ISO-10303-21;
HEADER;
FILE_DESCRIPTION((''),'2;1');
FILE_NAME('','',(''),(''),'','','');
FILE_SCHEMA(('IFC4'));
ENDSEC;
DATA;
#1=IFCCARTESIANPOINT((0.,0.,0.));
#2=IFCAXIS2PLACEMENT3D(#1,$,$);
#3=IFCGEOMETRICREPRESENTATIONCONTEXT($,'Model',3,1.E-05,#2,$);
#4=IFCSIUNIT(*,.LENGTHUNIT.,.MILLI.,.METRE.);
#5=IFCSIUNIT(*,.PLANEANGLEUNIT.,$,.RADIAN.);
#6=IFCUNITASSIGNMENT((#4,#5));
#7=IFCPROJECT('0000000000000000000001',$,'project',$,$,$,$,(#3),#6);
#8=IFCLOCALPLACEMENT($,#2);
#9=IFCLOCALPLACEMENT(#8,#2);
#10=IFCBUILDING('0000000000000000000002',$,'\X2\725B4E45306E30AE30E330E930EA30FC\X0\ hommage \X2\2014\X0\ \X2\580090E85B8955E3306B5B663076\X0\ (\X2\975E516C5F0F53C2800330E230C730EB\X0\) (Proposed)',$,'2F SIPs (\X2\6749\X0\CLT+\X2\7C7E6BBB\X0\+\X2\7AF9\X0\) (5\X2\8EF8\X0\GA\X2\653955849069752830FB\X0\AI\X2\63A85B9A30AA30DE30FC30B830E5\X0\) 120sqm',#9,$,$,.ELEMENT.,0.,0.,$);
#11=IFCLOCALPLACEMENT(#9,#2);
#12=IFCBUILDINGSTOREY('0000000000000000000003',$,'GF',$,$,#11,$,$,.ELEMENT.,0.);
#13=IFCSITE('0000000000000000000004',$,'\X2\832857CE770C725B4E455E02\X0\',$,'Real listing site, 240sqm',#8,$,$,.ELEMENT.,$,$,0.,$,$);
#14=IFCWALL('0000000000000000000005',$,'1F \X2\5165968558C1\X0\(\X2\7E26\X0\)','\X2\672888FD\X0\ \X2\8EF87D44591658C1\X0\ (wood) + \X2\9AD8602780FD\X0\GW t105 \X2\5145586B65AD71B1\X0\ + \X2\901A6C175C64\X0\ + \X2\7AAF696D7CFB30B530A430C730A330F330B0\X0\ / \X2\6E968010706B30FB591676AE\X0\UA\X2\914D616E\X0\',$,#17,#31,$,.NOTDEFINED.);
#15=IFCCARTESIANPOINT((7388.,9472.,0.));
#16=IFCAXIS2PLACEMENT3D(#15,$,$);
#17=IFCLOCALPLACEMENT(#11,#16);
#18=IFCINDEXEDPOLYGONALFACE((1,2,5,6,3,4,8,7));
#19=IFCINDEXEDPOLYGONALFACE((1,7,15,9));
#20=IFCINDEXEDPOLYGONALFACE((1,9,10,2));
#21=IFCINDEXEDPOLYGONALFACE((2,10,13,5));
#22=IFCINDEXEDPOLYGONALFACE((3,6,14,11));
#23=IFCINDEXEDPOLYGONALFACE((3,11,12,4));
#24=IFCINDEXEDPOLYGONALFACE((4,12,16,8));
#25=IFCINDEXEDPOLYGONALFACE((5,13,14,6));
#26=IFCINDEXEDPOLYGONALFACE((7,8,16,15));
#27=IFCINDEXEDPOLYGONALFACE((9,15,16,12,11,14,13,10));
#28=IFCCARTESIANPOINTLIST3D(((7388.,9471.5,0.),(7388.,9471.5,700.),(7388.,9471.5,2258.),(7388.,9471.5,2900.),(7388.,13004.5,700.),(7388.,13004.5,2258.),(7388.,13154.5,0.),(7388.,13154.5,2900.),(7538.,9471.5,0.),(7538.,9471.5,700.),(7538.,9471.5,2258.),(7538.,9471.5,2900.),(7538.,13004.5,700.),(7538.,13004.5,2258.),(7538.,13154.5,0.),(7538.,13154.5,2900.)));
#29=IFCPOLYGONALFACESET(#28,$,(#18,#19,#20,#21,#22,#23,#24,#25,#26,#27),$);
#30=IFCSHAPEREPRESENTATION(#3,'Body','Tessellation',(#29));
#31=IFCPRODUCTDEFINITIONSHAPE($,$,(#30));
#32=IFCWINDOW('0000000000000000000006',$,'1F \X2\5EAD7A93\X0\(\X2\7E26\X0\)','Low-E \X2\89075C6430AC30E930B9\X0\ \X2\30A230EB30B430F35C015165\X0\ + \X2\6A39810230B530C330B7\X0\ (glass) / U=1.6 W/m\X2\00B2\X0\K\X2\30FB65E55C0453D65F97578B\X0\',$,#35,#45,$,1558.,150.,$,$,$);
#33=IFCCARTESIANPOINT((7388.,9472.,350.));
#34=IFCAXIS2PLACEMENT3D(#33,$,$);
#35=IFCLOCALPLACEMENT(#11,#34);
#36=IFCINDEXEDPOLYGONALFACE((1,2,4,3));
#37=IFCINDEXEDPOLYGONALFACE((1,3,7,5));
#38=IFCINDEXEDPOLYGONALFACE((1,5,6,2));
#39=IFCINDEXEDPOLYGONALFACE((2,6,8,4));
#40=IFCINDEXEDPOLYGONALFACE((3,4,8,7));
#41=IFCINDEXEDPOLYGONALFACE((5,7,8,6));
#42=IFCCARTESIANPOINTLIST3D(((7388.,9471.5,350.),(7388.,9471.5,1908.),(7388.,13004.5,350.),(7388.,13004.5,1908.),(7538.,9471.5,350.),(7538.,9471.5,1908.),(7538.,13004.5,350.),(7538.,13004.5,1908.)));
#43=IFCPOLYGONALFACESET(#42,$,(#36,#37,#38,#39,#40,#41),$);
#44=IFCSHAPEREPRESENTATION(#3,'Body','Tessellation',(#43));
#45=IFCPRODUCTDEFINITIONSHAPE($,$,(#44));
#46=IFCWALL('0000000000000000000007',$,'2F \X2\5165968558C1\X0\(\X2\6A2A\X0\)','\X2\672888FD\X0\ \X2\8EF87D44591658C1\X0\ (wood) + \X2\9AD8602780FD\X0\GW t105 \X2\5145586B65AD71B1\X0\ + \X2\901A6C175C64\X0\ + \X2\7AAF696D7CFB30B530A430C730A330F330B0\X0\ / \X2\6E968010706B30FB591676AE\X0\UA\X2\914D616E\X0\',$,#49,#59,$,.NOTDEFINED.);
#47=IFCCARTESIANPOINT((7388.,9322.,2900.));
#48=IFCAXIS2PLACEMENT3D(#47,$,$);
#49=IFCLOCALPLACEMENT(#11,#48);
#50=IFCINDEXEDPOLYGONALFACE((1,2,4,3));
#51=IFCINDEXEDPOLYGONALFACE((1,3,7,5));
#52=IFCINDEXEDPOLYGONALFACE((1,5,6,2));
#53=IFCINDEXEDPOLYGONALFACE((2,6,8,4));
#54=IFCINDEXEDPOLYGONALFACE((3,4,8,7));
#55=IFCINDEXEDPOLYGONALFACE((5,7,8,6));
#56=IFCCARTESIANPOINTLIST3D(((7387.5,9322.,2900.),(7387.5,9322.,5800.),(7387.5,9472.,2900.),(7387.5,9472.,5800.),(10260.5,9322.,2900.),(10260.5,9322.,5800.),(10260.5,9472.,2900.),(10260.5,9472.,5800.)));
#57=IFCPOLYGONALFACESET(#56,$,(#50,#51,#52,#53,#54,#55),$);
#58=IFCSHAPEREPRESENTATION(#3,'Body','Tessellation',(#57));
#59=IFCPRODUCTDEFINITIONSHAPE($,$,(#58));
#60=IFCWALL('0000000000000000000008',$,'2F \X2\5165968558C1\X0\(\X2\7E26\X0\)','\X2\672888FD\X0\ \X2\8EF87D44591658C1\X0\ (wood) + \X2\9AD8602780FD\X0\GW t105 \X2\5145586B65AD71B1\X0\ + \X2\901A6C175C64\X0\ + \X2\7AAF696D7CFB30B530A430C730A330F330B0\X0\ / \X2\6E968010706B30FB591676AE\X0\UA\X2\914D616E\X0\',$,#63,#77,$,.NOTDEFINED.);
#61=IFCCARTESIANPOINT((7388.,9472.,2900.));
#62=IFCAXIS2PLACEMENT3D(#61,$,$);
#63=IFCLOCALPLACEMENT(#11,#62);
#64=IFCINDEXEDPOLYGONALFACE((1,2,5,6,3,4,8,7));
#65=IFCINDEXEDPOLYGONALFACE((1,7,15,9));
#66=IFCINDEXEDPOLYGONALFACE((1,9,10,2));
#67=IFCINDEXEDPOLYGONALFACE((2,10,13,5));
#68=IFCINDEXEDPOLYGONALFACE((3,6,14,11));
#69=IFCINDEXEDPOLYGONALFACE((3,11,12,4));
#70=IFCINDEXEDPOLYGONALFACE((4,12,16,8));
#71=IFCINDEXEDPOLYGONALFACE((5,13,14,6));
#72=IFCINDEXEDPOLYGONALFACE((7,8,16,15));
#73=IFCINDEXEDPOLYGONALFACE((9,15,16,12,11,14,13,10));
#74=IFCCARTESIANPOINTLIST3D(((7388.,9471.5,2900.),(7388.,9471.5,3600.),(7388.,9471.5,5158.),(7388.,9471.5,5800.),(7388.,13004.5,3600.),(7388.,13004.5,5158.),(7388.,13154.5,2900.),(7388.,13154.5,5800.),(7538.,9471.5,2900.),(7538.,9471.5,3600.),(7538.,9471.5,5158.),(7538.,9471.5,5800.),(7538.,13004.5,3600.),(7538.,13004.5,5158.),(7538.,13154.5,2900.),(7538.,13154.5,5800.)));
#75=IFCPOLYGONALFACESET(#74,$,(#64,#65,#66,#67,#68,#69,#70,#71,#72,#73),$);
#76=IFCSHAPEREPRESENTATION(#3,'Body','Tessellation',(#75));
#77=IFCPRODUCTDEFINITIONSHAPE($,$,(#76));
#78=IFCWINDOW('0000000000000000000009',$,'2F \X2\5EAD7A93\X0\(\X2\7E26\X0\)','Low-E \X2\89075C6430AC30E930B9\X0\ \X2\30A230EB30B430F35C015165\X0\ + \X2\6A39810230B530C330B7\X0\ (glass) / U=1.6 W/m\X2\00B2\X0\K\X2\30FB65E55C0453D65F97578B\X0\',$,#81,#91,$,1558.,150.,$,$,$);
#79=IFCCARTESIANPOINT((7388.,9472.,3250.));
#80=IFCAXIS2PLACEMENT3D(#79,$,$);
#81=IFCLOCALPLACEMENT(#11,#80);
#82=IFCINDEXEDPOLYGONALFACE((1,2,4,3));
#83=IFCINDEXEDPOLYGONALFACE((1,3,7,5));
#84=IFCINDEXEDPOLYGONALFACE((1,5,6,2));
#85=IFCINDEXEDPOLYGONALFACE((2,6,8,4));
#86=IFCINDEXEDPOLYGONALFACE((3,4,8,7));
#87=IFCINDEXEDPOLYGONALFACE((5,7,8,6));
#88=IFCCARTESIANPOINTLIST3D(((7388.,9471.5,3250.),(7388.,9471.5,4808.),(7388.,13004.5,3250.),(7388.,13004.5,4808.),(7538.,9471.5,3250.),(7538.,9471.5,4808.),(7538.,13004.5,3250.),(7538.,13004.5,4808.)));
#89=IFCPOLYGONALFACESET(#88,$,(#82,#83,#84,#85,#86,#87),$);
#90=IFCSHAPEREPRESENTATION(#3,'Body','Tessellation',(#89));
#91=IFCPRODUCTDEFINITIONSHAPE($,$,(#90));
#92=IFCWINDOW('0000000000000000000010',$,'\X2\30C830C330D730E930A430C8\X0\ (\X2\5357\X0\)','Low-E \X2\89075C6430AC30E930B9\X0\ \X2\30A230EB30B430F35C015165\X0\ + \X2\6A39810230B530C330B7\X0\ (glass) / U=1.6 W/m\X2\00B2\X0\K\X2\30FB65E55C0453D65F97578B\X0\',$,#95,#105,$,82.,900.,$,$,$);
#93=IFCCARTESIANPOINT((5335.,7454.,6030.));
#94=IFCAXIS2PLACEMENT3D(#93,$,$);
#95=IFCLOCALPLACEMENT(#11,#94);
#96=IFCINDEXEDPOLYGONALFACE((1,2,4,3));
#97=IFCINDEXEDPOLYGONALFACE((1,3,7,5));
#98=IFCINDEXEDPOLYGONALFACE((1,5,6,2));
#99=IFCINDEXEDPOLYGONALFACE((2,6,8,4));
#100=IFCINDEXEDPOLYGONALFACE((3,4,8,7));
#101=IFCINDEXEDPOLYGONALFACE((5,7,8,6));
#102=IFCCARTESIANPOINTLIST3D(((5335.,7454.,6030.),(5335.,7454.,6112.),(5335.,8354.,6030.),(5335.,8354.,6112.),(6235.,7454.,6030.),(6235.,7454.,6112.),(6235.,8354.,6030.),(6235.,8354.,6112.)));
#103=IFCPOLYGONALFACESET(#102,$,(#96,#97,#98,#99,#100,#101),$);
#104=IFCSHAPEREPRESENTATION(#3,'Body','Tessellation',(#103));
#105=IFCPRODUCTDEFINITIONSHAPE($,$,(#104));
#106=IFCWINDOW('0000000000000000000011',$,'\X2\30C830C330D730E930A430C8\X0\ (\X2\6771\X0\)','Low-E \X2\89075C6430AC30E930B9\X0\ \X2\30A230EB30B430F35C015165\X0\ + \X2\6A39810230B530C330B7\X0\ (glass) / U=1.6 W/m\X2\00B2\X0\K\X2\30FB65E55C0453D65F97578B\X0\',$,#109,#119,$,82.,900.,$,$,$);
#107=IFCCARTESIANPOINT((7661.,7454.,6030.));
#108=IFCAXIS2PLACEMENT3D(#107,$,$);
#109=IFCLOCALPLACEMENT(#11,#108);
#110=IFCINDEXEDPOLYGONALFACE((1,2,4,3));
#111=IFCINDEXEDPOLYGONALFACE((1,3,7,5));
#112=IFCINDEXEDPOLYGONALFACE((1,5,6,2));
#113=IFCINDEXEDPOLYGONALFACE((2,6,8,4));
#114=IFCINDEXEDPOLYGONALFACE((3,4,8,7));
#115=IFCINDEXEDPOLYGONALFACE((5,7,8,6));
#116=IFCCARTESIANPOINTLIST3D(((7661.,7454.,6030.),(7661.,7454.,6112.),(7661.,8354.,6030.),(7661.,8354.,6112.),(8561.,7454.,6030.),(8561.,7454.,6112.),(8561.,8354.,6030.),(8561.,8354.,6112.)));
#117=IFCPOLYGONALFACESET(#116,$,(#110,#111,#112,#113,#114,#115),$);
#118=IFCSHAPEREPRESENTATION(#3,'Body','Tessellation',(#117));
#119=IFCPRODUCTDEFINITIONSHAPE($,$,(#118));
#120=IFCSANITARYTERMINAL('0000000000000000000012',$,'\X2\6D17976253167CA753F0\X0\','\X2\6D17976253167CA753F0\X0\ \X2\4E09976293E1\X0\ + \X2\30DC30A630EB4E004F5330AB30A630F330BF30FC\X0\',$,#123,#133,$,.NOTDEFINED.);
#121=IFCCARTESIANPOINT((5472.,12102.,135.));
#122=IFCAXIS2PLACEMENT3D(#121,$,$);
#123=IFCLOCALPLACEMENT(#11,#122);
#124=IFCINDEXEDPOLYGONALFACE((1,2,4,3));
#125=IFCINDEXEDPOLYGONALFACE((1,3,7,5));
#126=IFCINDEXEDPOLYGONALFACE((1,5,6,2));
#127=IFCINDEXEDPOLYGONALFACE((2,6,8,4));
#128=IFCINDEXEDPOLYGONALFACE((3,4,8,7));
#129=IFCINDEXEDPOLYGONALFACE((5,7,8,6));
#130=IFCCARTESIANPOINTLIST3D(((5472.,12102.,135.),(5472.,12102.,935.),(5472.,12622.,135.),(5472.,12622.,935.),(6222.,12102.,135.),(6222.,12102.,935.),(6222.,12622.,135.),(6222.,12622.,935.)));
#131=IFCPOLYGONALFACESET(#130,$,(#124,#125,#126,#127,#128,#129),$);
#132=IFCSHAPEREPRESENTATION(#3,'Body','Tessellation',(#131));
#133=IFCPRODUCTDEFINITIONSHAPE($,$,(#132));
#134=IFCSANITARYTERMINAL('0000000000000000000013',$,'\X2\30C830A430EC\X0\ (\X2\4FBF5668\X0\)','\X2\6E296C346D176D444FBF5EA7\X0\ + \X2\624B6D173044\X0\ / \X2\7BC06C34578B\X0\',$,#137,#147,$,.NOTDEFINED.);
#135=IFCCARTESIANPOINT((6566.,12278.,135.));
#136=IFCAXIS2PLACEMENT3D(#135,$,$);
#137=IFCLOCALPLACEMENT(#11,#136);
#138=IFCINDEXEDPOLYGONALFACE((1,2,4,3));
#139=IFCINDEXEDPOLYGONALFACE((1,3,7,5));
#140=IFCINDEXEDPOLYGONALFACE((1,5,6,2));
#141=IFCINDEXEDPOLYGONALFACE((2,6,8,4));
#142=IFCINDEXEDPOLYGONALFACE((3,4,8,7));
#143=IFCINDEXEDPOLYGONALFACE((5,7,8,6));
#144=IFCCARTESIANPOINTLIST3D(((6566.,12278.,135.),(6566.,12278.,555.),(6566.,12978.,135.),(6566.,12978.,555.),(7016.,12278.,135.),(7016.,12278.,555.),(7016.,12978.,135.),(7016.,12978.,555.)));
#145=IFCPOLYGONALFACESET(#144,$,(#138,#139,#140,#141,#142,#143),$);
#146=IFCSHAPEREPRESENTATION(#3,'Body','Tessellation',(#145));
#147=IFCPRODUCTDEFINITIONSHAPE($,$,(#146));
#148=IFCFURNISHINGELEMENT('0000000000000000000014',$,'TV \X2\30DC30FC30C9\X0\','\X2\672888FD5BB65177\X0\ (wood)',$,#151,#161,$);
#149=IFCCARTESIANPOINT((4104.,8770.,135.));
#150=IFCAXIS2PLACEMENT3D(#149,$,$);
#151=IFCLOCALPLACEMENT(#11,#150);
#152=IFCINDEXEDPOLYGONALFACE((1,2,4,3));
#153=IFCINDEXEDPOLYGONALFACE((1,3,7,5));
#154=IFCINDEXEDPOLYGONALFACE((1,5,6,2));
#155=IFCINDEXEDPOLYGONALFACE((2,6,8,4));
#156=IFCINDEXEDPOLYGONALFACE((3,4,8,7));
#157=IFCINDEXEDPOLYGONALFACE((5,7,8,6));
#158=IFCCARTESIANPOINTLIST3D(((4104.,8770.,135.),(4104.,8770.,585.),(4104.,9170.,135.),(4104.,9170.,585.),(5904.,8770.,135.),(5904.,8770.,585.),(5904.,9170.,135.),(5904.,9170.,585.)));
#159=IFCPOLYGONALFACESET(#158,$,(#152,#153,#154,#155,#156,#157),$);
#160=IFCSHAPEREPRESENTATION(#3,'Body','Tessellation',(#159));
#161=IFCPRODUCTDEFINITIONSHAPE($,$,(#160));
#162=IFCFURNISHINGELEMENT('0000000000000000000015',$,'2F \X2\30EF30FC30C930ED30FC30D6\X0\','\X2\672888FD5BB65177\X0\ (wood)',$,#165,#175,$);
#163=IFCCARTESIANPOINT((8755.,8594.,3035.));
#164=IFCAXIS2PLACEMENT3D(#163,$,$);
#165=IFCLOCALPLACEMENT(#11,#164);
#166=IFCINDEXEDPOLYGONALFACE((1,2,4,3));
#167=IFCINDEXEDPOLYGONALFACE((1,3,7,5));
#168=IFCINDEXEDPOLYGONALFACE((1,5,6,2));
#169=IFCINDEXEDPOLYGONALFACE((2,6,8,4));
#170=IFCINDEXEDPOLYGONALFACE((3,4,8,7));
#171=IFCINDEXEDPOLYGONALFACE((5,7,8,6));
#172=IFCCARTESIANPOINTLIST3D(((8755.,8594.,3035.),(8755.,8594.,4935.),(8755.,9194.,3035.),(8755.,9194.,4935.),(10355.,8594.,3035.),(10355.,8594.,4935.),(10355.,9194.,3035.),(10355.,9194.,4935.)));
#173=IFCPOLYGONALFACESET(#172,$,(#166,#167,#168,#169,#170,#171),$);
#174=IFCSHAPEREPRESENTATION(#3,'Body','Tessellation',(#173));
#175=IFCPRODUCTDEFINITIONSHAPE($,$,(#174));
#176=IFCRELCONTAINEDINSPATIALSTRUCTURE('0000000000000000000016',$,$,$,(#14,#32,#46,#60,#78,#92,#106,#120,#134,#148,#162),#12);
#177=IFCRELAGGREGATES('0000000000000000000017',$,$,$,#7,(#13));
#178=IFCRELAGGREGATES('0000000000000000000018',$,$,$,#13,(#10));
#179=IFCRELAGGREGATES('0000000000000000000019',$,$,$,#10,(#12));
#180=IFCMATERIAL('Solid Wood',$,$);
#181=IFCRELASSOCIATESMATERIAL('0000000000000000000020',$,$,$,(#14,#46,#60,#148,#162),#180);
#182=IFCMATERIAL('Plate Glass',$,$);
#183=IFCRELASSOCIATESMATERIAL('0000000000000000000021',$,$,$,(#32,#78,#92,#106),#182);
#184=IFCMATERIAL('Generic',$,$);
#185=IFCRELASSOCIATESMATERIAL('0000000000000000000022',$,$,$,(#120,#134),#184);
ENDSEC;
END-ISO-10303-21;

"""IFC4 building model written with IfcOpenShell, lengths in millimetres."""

from ifc_helpers import new_model, si_unit, frame, frame_2d, origin, place, context, project, spatial, rectangle, extrude, material, element, fill, save


model = new_model("IFC4")

# Units and contexts
model_context = context("Model", 3, precision=1e-05, world=origin())
ifc_project = project(units=[si_unit("LENGTHUNIT", "METRE", prefix="MILLI"), si_unit("PLANEANGLEUNIT", "RADIAN")], contexts=[model_context])

# Site, building, storey
site_placement = place(None, origin())
site = spatial("IfcSite", under=ifc_project, at=site_placement, Name="茨城県牛久市", ObjectType="Real listing site, 240sqm", CompositionType="ELEMENT", RefElevation=0.0)
building_placement = place(site_placement, origin())
building = spatial("IfcBuilding", under=site, at=building_placement, Name="牛久のギャラリー hommage — 堀部安嗣に学ぶ (非公式参考モデル) (Proposed)", ObjectType="2F SIPs (杉CLT+籾殻+竹) (5軸GA改善適用・AI推定オマージュ) 120sqm", CompositionType="ELEMENT", ElevationOfRefHeight=0.0, ElevationOfTerrain=0.0)
storey_placement = place(building_placement, origin())
storey = spatial("IfcBuildingStorey", under=building, at=storey_placement, Name="GF", CompositionType="ELEMENT", Elevation=0.0)

# Shared definitions
ifc_material_1 = material(Name="Solid Wood")

# Wall, opening, window
wall_1_placement = place(storey_placement, frame((7388.0, 9472.0, 0.0)))
wall_1 = element("IfcWall", 1, at=wall_1_placement, inside=storey, material=ifc_material_1, Name="1F 入隅壁(縦)", Description="木製 軸組外壁 (wood) + 高性能GW t105 充填断熱 + 通気層 + 窯業系サイディング / 準耐火・外皮UA配慮", PredefinedType="NOTDEFINED", context=model_context, shape_type="SweptSolid", body=[
    extrude(rectangle(XDim=150.0, YDim=3683.0, at=frame_2d((75.0, 1841.0))), frame((7388.0, 9472.0, 0.0)), (0.0, 0.0, 1.0), 2900.0),
])
opening_1_placement = place(storey_placement, frame((7388.0, 9472.0, 350.0)))
opening_1 = element("IfcOpeningElement", 2, at=opening_1_placement, cuts=wall_1, PredefinedType="NOTDEFINED", context=model_context, shape_type="SweptSolid", body=[
    extrude(rectangle(XDim=150.0, YDim=3533.0, at=frame_2d((75.0, 1766.0))), frame((7388.0, 9472.0, 350.0)), (0.0, 0.0, 1.0), 1558.0),
])
ifc_material_2 = material(Name="Plate Glass")
window_1_placement = place(storey_placement, frame((7388.0, 9472.0, 350.0)))
window_1 = element("IfcWindow", 3, at=window_1_placement, inside=storey, material=ifc_material_2, Name="1F 庭窓(縦)", Description="Low-E 複層ガラス アルゴン封入 + 樹脂サッシ (glass) / U=1.6 W/m²K・日射取得型", OverallHeight=1558.0, OverallWidth=150.0, context=model_context, shape_type="SweptSolid", body=[
    extrude(rectangle(XDim=150.0, YDim=3533.0, at=frame_2d((75.0, 1766.0))), frame((7388.0, 9472.0, 350.0)), (0.0, 0.0, 1.0), 1558.0),
])
fill(opening_1, window_1)

# Wall
wall_2_placement = place(storey_placement, frame((7388.0, 9322.0, 2900.0)))
element("IfcWall", 4, at=wall_2_placement, inside=storey, material=ifc_material_1, Name="2F 入隅壁(横)", Description="木製 軸組外壁 (wood) + 高性能GW t105 充填断熱 + 通気層 + 窯業系サイディング / 準耐火・外皮UA配慮", PredefinedType="NOTDEFINED", context=model_context, shape_type="SweptSolid", body=[
    extrude(rectangle(XDim=2873.0, YDim=150.0, at=frame_2d((1436.0, 75.0))), frame((7388.0, 9322.0, 2900.0)), (0.0, 0.0, 1.0), 2900.0),
])

# Wall, opening, window
wall_3_placement = place(storey_placement, frame((7388.0, 9472.0, 2900.0)))
wall_3 = element("IfcWall", 5, at=wall_3_placement, inside=storey, material=ifc_material_1, Name="2F 入隅壁(縦)", Description="木製 軸組外壁 (wood) + 高性能GW t105 充填断熱 + 通気層 + 窯業系サイディング / 準耐火・外皮UA配慮", PredefinedType="NOTDEFINED", context=model_context, shape_type="SweptSolid", body=[
    extrude(rectangle(XDim=150.0, YDim=3683.0, at=frame_2d((75.0, 1841.0))), frame((7388.0, 9472.0, 2900.0)), (0.0, 0.0, 1.0), 2900.0),
])
opening_2_placement = place(storey_placement, frame((7388.0, 9472.0, 3250.0)))
opening_2 = element("IfcOpeningElement", 6, at=opening_2_placement, cuts=wall_3, PredefinedType="NOTDEFINED", context=model_context, shape_type="SweptSolid", body=[
    extrude(rectangle(XDim=150.0, YDim=3533.0, at=frame_2d((75.0, 1766.0))), frame((7388.0, 9472.0, 3250.0)), (0.0, 0.0, 1.0), 1558.0),
])
window_2_placement = place(storey_placement, frame((7388.0, 9472.0, 3250.0)))
window_2 = element("IfcWindow", 7, at=window_2_placement, inside=storey, material=ifc_material_2, Name="2F 庭窓(縦)", Description="Low-E 複層ガラス アルゴン封入 + 樹脂サッシ (glass) / U=1.6 W/m²K・日射取得型", OverallHeight=1558.0, OverallWidth=150.0, context=model_context, shape_type="SweptSolid", body=[
    extrude(rectangle(XDim=150.0, YDim=3533.0, at=frame_2d((75.0, 1766.0))), frame((7388.0, 9472.0, 3250.0)), (0.0, 0.0, 1.0), 1558.0),
])
fill(opening_2, window_2)

# Windows
window_3_placement = place(storey_placement, frame((5335.0, 7454.0, 6030.0)))
element("IfcWindow", 8, at=window_3_placement, inside=storey, material=ifc_material_2, Name="トップライト (南)", Description="Low-E 複層ガラス アルゴン封入 + 樹脂サッシ (glass) / U=1.6 W/m²K・日射取得型", OverallHeight=82.0, OverallWidth=900.0, context=model_context, shape_type="SweptSolid", body=[
    extrude(rectangle(XDim=900.0, YDim=900.0, at=frame_2d((450.0, 450.0))), frame((5335.0, 7454.0, 6030.0)), (0.0, 0.0, 1.0), 82.0),
])
window_4_placement = place(storey_placement, frame((7661.0, 7454.0, 6030.0)))
element("IfcWindow", 9, at=window_4_placement, inside=storey, material=ifc_material_2, Name="トップライト (東)", Description="Low-E 複層ガラス アルゴン封入 + 樹脂サッシ (glass) / U=1.6 W/m²K・日射取得型", OverallHeight=82.0, OverallWidth=900.0, context=model_context, shape_type="SweptSolid", body=[
    extrude(rectangle(XDim=900.0, YDim=900.0, at=frame_2d((450.0, 450.0))), frame((7661.0, 7454.0, 6030.0)), (0.0, 0.0, 1.0), 82.0),
])

# Sanitary terminals
ifc_material_3 = material(Name="Generic")
sanitary_terminal_1_placement = place(storey_placement, frame((5472.0, 12102.0, 135.0)))
element("IfcSanitaryTerminal", 10, at=sanitary_terminal_1_placement, inside=storey, material=ifc_material_3, Name="洗面化粧台", Description="洗面化粧台 三面鏡 + ボウル一体カウンター", PredefinedType="NOTDEFINED", context=model_context, shape_type="SweptSolid", body=[
    extrude(rectangle(XDim=750.0, YDim=520.0, at=frame_2d((375.0, 260.0))), frame((5472.0, 12102.0, 135.0)), (0.0, 0.0, 1.0), 800.0),
])
sanitary_terminal_2_placement = place(storey_placement, frame((6566.0, 12278.0, 135.0)))
element("IfcSanitaryTerminal", 11, at=sanitary_terminal_2_placement, inside=storey, material=ifc_material_3, Name="トイレ (便器)", Description="温水洗浄便座 + 手洗い / 節水型", PredefinedType="NOTDEFINED", context=model_context, shape_type="SweptSolid", body=[
    extrude(rectangle(XDim=450.0, YDim=700.0, at=frame_2d((225.0, 350.0))), frame((6566.0, 12278.0, 135.0)), (0.0, 0.0, 1.0), 420.0),
])

# Furnishing elements
furnishing_1_placement = place(storey_placement, frame((4104.0, 8770.0, 135.0)))
element("IfcFurnishingElement", 12, at=furnishing_1_placement, inside=storey, material=ifc_material_1, Name="TV ボード", Description="木製家具 (wood)", context=model_context, shape_type="SweptSolid", body=[
    extrude(rectangle(XDim=1800.0, YDim=400.0, at=frame_2d((900.0, 200.0))), frame((4104.0, 8770.0, 135.0)), (0.0, 0.0, 1.0), 450.0),
])
furnishing_2_placement = place(storey_placement, frame((8755.0, 8594.0, 3035.0)))
element("IfcFurnishingElement", 13, at=furnishing_2_placement, inside=storey, material=ifc_material_1, Name="2F ワードローブ", Description="木製家具 (wood)", context=model_context, shape_type="SweptSolid", body=[
    extrude(rectangle(XDim=1600.0, YDim=600.0, at=frame_2d((800.0, 300.0))), frame((8755.0, 8594.0, 3035.0)), (0.0, 0.0, 1.0), 1900.0),
])

save(model, "model.ifc")
